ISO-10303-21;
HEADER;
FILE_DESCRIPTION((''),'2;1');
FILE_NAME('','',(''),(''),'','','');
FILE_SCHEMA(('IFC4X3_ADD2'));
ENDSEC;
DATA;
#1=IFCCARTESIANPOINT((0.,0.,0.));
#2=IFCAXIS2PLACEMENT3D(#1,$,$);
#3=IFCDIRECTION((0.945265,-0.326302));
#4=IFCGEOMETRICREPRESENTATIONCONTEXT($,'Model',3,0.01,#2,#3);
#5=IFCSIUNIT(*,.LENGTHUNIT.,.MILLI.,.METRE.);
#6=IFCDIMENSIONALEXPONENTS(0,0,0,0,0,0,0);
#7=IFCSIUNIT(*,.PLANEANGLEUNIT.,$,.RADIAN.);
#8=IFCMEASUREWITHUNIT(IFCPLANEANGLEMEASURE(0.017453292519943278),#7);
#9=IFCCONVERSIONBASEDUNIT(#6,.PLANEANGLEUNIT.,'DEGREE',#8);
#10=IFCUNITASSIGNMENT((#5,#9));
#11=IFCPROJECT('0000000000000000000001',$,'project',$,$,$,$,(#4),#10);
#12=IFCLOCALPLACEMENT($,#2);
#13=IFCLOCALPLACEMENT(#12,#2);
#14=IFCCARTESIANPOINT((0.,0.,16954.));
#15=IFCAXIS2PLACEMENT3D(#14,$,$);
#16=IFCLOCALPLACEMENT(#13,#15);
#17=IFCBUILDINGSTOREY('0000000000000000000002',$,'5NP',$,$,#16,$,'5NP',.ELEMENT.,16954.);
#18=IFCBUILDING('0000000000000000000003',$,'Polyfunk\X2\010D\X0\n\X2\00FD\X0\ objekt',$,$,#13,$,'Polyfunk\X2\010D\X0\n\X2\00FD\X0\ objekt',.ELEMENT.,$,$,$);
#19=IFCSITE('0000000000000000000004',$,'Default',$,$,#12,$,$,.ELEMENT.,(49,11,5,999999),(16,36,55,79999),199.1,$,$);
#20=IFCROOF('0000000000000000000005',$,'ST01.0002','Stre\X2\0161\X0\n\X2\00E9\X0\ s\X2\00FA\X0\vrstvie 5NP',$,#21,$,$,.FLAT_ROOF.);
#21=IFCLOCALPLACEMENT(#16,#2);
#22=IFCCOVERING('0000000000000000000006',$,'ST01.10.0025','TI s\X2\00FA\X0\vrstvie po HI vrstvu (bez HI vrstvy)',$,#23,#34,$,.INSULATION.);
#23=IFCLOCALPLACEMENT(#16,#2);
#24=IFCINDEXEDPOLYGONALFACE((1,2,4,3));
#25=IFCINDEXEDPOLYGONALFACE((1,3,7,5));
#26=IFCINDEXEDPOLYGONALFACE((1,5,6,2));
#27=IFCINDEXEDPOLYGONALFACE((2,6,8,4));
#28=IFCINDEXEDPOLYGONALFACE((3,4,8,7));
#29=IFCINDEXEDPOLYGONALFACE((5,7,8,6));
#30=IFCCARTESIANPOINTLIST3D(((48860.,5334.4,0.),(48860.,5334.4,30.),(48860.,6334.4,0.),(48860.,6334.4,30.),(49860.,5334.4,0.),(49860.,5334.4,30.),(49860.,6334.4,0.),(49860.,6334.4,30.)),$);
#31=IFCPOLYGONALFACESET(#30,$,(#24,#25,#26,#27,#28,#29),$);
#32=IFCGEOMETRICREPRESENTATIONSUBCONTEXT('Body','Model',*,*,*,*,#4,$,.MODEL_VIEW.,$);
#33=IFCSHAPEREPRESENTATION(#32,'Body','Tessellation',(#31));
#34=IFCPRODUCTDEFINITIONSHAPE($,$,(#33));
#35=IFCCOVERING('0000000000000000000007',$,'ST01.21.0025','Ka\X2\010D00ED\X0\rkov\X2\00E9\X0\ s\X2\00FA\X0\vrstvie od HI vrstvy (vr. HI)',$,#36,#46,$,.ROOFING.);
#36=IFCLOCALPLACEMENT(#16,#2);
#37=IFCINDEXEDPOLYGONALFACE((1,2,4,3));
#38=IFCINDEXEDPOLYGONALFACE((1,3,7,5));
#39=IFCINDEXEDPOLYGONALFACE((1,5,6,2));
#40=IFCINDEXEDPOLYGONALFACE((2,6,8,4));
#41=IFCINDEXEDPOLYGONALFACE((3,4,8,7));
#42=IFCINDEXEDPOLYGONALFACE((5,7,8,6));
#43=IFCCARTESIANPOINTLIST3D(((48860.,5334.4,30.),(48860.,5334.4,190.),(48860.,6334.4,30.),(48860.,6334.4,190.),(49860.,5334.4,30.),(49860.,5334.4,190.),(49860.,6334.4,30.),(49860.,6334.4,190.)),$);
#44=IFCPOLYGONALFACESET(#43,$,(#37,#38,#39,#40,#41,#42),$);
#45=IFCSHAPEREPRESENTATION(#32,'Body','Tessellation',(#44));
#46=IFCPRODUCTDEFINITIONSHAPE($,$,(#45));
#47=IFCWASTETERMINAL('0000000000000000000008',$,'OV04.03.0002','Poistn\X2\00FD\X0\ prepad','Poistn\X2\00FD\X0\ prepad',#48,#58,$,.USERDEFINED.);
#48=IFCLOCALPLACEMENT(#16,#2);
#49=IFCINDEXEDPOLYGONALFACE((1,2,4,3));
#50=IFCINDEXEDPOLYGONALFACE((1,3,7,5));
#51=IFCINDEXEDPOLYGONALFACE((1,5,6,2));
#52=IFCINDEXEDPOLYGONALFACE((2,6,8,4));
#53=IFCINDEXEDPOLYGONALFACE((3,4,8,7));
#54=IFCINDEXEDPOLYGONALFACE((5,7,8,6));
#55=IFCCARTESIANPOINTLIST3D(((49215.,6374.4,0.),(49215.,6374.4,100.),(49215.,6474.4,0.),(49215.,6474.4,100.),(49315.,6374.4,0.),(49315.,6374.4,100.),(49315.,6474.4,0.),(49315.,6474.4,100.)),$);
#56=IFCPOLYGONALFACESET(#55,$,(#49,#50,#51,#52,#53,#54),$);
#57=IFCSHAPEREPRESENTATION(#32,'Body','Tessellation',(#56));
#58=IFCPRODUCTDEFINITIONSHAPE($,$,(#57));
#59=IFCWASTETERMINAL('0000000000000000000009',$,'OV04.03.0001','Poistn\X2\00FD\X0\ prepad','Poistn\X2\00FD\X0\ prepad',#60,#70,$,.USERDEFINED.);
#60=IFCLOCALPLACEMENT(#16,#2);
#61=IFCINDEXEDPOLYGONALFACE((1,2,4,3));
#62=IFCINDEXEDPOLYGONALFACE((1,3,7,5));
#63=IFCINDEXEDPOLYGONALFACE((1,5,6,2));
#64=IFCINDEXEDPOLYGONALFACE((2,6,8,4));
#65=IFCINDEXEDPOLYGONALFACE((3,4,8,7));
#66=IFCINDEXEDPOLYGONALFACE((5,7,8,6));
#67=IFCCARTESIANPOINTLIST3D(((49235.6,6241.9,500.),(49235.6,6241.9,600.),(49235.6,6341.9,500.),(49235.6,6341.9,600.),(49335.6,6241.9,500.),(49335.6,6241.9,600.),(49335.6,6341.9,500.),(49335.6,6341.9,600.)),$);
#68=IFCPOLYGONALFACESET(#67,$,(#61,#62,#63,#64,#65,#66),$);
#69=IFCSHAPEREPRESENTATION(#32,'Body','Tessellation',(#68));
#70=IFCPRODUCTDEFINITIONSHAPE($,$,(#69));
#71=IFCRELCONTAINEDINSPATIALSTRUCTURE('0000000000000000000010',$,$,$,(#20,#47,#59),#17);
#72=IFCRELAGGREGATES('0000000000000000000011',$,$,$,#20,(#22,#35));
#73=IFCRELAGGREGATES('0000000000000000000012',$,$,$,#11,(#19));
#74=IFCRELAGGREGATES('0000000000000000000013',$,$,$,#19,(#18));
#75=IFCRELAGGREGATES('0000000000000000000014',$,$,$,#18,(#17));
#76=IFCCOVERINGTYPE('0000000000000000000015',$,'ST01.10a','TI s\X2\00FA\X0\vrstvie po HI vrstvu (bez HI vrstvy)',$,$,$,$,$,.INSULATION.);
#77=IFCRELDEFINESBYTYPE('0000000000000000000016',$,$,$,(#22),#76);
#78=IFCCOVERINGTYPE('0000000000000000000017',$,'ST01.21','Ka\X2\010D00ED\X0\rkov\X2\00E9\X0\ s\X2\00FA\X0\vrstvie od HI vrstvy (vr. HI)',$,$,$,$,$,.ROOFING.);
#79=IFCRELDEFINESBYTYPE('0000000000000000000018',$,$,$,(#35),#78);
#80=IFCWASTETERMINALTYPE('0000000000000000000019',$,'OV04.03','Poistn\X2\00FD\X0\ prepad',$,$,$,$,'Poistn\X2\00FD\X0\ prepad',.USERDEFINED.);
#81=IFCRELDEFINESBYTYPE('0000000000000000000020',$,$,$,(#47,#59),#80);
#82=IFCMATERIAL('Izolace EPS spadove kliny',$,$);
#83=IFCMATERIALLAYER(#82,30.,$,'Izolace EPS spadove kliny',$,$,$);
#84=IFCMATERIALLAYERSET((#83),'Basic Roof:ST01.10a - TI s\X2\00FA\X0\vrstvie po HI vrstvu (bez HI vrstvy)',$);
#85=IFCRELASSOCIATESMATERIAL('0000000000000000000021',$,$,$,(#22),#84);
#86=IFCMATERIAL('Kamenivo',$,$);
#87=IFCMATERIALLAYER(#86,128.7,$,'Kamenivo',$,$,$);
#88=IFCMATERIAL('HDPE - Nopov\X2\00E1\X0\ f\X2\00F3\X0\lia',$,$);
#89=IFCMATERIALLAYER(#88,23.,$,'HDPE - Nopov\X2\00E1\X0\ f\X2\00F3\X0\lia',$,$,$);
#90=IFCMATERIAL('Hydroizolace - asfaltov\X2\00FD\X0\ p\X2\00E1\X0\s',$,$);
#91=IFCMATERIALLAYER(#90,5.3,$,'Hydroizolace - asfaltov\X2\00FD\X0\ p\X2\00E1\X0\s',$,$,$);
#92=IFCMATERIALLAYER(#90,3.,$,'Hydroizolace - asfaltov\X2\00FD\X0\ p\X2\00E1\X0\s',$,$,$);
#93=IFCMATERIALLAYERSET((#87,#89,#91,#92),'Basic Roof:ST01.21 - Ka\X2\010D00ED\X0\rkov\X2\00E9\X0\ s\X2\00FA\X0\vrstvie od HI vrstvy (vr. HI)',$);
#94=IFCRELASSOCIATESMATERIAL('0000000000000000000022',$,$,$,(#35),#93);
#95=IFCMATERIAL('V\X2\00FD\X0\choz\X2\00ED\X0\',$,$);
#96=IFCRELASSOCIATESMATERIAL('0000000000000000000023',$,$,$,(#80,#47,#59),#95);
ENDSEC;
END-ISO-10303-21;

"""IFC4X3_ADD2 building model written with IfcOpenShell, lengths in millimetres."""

from ifc_helpers import new_model, entity, si_unit, converted_unit, direction, frame, frame_2d, origin, origin_2d_with_axis, place, context, subcontext, project, spatial, rectangle, extrude, source, transform, mapped, material, layer, layer_set, type_object, type_shapes, element, aggregate, save


model = new_model("IFC4X3_ADD2")

# Units and contexts
model_context = context("Model", 3, precision=0.01, world=origin(), true_north=direction((0.945265, -0.326302)))
body_context = subcontext(model_context, "Body", "Model", "MODEL_VIEW")
ifc_project = project(units=[si_unit("LENGTHUNIT", "METRE", prefix="MILLI"), converted_unit("PLANEANGLEUNIT", "DEGREE", entity("IfcPlaneAngleMeasure", 0.017453292519943278), si_unit("PLANEANGLEUNIT", "RADIAN"), dimensions=[0, 0, 0, 0, 0, 0, 0])], contexts=[model_context])

# Site, building, storey
site_placement = place(None, origin())
site = spatial("IfcSite", under=ifc_project, at=site_placement, Name="Default", CompositionType="ELEMENT", RefLatitude=(49, 11, 5, 999999), RefLongitude=(16, 36, 55, 79999), RefElevation=199.1)
building_placement = place(site_placement, origin())
building = spatial("IfcBuilding", under=site, at=building_placement, Name="Polyfunkčný objekt", LongName="Polyfunkčný objekt", CompositionType="ELEMENT")
storey_placement = place(building_placement, frame((0.0, 0.0, 16954.0)))
storey = spatial("IfcBuildingStorey", under=building, at=storey_placement, Name="5NP", LongName="5NP", CompositionType="ELEMENT", Elevation=16954.0)

# Roof, coverings
roof = element("IfcRoof", 1, inside=storey, Name="ST01.0002", Description="Strešné súvrstvie 5NP", PredefinedType="FLAT_ROOF")
ifc_material_1 = material(Name="Izolace EPS spadove kliny")
ifc_layer_1 = layer(ifc_material_1, 30.0, Name="Izolace EPS spadove kliny")
ifc_layer_set_1 = layer_set([ifc_layer_1], Name="Basic Roof:ST01.10a - TI súvrstvie po HI vrstvu (bez HI vrstvy)")
covering_type_1 = type_object("IfcCoveringType", Name="ST01.10a", Description="TI súvrstvie po HI vrstvu (bez HI vrstvy)", PredefinedType="INSULATION")
placement_1 = place(storey_placement, frame((48860.0, 5334.4, 0.0)))
covering_1_placement = place(placement_1, origin())
covering_1 = element("IfcCovering", 2, at=covering_1_placement, type_object=covering_type_1, material=ifc_layer_set_1, Name="ST01.10.0025", Description="TI súvrstvie po HI vrstvu (bez HI vrstvy)", PredefinedType="INSULATION", context=body_context, shape_type="SweptSolid", body=[
    extrude(rectangle(XDim=1000.0, YDim=1000.0, at=origin_2d_with_axis()), frame((500.0, 500.0, 0.0)), (0.0, 0.0, 1.0), 30.0),
])
ifc_material_2 = material(Name="Kamenivo")
ifc_layer_2 = layer(ifc_material_2, 128.7, Name="Kamenivo")
ifc_material_3 = material(Name="HDPE - Nopová fólia")
ifc_layer_3 = layer(ifc_material_3, 23.0, Name="HDPE - Nopová fólia")
ifc_material_4 = material(Name="Hydroizolace - asfaltový pás")
ifc_layer_4 = layer(ifc_material_4, 5.3, Name="Hydroizolace - asfaltový pás")
ifc_layer_5 = layer(ifc_material_4, 3.0, Name="Hydroizolace - asfaltový pás")
ifc_layer_set_2 = layer_set([ifc_layer_2, ifc_layer_3, ifc_layer_4, ifc_layer_5], Name="Basic Roof:ST01.21 - Kačírkové súvrstvie od HI vrstvy (vr. HI)")
covering_type_2 = type_object("IfcCoveringType", Name="ST01.21", Description="Kačírkové súvrstvie od HI vrstvy (vr. HI)", PredefinedType="ROOFING")
placement_2 = place(storey_placement, frame((48860.0, 5334.4, 30.0)))
covering_2_placement = place(placement_2, origin())
covering_2 = element("IfcCovering", 3, at=covering_2_placement, type_object=covering_type_2, material=ifc_layer_set_2, Name="ST01.21.0025", Description="Kačírkové súvrstvie od HI vrstvy (vr. HI)", PredefinedType="ROOFING", context=body_context, shape_type="SweptSolid", body=[
    extrude(rectangle(XDim=1000.0, YDim=1000.0, at=frame_2d((0.0, 0.0), x_axis=(-1.0, 0.0))), frame((500.0, 500.0, 0.0)), (0.0, 0.0, 1.0), 160.0),
])
aggregate(roof, [covering_1, covering_2])

# Waste terminals
ifc_material_5 = material(Name="Výchozí")
waste_terminal_type = type_object("IfcWasteTerminalType", Name="OV04.03", Description="Poistný prepad", ElementType="Poistný prepad", PredefinedType="USERDEFINED", material=ifc_material_5)
shared_shape = source(origin(), body_context, "Body", "SweptSolid", [
    extrude(rectangle(XDim=100.0, YDim=100.0, at=origin_2d_with_axis()), frame((0.0, 0.0, 0.0), z_axis=(0.0, 0.0, 1.0), x_axis=(0.0, 1.0, 0.0)), (0.0, 0.0, 1.0), 100.0),
])
type_shapes(waste_terminal_type, [shared_shape])
for number, where, name in (
    (4, (49265.0, 6424.4, 0.0), "OV04.03.0002"),
    (5, (49285.6, 6291.9, 500.0), "OV04.03.0001"),
):
    element("IfcWasteTerminal", number, at=place(storey_placement, frame(where)), inside=storey, type_object=waste_terminal_type, material=ifc_material_5, Name=name, Description="Poistný prepad", ObjectType="Poistný prepad", PredefinedType="USERDEFINED", context=body_context, shape_type="MappedRepresentation", body=[
        mapped(shared_shape, transform((0.0, 0.0, 0.0), scale=1.0)),
    ])

save(model, "model.ifc")
